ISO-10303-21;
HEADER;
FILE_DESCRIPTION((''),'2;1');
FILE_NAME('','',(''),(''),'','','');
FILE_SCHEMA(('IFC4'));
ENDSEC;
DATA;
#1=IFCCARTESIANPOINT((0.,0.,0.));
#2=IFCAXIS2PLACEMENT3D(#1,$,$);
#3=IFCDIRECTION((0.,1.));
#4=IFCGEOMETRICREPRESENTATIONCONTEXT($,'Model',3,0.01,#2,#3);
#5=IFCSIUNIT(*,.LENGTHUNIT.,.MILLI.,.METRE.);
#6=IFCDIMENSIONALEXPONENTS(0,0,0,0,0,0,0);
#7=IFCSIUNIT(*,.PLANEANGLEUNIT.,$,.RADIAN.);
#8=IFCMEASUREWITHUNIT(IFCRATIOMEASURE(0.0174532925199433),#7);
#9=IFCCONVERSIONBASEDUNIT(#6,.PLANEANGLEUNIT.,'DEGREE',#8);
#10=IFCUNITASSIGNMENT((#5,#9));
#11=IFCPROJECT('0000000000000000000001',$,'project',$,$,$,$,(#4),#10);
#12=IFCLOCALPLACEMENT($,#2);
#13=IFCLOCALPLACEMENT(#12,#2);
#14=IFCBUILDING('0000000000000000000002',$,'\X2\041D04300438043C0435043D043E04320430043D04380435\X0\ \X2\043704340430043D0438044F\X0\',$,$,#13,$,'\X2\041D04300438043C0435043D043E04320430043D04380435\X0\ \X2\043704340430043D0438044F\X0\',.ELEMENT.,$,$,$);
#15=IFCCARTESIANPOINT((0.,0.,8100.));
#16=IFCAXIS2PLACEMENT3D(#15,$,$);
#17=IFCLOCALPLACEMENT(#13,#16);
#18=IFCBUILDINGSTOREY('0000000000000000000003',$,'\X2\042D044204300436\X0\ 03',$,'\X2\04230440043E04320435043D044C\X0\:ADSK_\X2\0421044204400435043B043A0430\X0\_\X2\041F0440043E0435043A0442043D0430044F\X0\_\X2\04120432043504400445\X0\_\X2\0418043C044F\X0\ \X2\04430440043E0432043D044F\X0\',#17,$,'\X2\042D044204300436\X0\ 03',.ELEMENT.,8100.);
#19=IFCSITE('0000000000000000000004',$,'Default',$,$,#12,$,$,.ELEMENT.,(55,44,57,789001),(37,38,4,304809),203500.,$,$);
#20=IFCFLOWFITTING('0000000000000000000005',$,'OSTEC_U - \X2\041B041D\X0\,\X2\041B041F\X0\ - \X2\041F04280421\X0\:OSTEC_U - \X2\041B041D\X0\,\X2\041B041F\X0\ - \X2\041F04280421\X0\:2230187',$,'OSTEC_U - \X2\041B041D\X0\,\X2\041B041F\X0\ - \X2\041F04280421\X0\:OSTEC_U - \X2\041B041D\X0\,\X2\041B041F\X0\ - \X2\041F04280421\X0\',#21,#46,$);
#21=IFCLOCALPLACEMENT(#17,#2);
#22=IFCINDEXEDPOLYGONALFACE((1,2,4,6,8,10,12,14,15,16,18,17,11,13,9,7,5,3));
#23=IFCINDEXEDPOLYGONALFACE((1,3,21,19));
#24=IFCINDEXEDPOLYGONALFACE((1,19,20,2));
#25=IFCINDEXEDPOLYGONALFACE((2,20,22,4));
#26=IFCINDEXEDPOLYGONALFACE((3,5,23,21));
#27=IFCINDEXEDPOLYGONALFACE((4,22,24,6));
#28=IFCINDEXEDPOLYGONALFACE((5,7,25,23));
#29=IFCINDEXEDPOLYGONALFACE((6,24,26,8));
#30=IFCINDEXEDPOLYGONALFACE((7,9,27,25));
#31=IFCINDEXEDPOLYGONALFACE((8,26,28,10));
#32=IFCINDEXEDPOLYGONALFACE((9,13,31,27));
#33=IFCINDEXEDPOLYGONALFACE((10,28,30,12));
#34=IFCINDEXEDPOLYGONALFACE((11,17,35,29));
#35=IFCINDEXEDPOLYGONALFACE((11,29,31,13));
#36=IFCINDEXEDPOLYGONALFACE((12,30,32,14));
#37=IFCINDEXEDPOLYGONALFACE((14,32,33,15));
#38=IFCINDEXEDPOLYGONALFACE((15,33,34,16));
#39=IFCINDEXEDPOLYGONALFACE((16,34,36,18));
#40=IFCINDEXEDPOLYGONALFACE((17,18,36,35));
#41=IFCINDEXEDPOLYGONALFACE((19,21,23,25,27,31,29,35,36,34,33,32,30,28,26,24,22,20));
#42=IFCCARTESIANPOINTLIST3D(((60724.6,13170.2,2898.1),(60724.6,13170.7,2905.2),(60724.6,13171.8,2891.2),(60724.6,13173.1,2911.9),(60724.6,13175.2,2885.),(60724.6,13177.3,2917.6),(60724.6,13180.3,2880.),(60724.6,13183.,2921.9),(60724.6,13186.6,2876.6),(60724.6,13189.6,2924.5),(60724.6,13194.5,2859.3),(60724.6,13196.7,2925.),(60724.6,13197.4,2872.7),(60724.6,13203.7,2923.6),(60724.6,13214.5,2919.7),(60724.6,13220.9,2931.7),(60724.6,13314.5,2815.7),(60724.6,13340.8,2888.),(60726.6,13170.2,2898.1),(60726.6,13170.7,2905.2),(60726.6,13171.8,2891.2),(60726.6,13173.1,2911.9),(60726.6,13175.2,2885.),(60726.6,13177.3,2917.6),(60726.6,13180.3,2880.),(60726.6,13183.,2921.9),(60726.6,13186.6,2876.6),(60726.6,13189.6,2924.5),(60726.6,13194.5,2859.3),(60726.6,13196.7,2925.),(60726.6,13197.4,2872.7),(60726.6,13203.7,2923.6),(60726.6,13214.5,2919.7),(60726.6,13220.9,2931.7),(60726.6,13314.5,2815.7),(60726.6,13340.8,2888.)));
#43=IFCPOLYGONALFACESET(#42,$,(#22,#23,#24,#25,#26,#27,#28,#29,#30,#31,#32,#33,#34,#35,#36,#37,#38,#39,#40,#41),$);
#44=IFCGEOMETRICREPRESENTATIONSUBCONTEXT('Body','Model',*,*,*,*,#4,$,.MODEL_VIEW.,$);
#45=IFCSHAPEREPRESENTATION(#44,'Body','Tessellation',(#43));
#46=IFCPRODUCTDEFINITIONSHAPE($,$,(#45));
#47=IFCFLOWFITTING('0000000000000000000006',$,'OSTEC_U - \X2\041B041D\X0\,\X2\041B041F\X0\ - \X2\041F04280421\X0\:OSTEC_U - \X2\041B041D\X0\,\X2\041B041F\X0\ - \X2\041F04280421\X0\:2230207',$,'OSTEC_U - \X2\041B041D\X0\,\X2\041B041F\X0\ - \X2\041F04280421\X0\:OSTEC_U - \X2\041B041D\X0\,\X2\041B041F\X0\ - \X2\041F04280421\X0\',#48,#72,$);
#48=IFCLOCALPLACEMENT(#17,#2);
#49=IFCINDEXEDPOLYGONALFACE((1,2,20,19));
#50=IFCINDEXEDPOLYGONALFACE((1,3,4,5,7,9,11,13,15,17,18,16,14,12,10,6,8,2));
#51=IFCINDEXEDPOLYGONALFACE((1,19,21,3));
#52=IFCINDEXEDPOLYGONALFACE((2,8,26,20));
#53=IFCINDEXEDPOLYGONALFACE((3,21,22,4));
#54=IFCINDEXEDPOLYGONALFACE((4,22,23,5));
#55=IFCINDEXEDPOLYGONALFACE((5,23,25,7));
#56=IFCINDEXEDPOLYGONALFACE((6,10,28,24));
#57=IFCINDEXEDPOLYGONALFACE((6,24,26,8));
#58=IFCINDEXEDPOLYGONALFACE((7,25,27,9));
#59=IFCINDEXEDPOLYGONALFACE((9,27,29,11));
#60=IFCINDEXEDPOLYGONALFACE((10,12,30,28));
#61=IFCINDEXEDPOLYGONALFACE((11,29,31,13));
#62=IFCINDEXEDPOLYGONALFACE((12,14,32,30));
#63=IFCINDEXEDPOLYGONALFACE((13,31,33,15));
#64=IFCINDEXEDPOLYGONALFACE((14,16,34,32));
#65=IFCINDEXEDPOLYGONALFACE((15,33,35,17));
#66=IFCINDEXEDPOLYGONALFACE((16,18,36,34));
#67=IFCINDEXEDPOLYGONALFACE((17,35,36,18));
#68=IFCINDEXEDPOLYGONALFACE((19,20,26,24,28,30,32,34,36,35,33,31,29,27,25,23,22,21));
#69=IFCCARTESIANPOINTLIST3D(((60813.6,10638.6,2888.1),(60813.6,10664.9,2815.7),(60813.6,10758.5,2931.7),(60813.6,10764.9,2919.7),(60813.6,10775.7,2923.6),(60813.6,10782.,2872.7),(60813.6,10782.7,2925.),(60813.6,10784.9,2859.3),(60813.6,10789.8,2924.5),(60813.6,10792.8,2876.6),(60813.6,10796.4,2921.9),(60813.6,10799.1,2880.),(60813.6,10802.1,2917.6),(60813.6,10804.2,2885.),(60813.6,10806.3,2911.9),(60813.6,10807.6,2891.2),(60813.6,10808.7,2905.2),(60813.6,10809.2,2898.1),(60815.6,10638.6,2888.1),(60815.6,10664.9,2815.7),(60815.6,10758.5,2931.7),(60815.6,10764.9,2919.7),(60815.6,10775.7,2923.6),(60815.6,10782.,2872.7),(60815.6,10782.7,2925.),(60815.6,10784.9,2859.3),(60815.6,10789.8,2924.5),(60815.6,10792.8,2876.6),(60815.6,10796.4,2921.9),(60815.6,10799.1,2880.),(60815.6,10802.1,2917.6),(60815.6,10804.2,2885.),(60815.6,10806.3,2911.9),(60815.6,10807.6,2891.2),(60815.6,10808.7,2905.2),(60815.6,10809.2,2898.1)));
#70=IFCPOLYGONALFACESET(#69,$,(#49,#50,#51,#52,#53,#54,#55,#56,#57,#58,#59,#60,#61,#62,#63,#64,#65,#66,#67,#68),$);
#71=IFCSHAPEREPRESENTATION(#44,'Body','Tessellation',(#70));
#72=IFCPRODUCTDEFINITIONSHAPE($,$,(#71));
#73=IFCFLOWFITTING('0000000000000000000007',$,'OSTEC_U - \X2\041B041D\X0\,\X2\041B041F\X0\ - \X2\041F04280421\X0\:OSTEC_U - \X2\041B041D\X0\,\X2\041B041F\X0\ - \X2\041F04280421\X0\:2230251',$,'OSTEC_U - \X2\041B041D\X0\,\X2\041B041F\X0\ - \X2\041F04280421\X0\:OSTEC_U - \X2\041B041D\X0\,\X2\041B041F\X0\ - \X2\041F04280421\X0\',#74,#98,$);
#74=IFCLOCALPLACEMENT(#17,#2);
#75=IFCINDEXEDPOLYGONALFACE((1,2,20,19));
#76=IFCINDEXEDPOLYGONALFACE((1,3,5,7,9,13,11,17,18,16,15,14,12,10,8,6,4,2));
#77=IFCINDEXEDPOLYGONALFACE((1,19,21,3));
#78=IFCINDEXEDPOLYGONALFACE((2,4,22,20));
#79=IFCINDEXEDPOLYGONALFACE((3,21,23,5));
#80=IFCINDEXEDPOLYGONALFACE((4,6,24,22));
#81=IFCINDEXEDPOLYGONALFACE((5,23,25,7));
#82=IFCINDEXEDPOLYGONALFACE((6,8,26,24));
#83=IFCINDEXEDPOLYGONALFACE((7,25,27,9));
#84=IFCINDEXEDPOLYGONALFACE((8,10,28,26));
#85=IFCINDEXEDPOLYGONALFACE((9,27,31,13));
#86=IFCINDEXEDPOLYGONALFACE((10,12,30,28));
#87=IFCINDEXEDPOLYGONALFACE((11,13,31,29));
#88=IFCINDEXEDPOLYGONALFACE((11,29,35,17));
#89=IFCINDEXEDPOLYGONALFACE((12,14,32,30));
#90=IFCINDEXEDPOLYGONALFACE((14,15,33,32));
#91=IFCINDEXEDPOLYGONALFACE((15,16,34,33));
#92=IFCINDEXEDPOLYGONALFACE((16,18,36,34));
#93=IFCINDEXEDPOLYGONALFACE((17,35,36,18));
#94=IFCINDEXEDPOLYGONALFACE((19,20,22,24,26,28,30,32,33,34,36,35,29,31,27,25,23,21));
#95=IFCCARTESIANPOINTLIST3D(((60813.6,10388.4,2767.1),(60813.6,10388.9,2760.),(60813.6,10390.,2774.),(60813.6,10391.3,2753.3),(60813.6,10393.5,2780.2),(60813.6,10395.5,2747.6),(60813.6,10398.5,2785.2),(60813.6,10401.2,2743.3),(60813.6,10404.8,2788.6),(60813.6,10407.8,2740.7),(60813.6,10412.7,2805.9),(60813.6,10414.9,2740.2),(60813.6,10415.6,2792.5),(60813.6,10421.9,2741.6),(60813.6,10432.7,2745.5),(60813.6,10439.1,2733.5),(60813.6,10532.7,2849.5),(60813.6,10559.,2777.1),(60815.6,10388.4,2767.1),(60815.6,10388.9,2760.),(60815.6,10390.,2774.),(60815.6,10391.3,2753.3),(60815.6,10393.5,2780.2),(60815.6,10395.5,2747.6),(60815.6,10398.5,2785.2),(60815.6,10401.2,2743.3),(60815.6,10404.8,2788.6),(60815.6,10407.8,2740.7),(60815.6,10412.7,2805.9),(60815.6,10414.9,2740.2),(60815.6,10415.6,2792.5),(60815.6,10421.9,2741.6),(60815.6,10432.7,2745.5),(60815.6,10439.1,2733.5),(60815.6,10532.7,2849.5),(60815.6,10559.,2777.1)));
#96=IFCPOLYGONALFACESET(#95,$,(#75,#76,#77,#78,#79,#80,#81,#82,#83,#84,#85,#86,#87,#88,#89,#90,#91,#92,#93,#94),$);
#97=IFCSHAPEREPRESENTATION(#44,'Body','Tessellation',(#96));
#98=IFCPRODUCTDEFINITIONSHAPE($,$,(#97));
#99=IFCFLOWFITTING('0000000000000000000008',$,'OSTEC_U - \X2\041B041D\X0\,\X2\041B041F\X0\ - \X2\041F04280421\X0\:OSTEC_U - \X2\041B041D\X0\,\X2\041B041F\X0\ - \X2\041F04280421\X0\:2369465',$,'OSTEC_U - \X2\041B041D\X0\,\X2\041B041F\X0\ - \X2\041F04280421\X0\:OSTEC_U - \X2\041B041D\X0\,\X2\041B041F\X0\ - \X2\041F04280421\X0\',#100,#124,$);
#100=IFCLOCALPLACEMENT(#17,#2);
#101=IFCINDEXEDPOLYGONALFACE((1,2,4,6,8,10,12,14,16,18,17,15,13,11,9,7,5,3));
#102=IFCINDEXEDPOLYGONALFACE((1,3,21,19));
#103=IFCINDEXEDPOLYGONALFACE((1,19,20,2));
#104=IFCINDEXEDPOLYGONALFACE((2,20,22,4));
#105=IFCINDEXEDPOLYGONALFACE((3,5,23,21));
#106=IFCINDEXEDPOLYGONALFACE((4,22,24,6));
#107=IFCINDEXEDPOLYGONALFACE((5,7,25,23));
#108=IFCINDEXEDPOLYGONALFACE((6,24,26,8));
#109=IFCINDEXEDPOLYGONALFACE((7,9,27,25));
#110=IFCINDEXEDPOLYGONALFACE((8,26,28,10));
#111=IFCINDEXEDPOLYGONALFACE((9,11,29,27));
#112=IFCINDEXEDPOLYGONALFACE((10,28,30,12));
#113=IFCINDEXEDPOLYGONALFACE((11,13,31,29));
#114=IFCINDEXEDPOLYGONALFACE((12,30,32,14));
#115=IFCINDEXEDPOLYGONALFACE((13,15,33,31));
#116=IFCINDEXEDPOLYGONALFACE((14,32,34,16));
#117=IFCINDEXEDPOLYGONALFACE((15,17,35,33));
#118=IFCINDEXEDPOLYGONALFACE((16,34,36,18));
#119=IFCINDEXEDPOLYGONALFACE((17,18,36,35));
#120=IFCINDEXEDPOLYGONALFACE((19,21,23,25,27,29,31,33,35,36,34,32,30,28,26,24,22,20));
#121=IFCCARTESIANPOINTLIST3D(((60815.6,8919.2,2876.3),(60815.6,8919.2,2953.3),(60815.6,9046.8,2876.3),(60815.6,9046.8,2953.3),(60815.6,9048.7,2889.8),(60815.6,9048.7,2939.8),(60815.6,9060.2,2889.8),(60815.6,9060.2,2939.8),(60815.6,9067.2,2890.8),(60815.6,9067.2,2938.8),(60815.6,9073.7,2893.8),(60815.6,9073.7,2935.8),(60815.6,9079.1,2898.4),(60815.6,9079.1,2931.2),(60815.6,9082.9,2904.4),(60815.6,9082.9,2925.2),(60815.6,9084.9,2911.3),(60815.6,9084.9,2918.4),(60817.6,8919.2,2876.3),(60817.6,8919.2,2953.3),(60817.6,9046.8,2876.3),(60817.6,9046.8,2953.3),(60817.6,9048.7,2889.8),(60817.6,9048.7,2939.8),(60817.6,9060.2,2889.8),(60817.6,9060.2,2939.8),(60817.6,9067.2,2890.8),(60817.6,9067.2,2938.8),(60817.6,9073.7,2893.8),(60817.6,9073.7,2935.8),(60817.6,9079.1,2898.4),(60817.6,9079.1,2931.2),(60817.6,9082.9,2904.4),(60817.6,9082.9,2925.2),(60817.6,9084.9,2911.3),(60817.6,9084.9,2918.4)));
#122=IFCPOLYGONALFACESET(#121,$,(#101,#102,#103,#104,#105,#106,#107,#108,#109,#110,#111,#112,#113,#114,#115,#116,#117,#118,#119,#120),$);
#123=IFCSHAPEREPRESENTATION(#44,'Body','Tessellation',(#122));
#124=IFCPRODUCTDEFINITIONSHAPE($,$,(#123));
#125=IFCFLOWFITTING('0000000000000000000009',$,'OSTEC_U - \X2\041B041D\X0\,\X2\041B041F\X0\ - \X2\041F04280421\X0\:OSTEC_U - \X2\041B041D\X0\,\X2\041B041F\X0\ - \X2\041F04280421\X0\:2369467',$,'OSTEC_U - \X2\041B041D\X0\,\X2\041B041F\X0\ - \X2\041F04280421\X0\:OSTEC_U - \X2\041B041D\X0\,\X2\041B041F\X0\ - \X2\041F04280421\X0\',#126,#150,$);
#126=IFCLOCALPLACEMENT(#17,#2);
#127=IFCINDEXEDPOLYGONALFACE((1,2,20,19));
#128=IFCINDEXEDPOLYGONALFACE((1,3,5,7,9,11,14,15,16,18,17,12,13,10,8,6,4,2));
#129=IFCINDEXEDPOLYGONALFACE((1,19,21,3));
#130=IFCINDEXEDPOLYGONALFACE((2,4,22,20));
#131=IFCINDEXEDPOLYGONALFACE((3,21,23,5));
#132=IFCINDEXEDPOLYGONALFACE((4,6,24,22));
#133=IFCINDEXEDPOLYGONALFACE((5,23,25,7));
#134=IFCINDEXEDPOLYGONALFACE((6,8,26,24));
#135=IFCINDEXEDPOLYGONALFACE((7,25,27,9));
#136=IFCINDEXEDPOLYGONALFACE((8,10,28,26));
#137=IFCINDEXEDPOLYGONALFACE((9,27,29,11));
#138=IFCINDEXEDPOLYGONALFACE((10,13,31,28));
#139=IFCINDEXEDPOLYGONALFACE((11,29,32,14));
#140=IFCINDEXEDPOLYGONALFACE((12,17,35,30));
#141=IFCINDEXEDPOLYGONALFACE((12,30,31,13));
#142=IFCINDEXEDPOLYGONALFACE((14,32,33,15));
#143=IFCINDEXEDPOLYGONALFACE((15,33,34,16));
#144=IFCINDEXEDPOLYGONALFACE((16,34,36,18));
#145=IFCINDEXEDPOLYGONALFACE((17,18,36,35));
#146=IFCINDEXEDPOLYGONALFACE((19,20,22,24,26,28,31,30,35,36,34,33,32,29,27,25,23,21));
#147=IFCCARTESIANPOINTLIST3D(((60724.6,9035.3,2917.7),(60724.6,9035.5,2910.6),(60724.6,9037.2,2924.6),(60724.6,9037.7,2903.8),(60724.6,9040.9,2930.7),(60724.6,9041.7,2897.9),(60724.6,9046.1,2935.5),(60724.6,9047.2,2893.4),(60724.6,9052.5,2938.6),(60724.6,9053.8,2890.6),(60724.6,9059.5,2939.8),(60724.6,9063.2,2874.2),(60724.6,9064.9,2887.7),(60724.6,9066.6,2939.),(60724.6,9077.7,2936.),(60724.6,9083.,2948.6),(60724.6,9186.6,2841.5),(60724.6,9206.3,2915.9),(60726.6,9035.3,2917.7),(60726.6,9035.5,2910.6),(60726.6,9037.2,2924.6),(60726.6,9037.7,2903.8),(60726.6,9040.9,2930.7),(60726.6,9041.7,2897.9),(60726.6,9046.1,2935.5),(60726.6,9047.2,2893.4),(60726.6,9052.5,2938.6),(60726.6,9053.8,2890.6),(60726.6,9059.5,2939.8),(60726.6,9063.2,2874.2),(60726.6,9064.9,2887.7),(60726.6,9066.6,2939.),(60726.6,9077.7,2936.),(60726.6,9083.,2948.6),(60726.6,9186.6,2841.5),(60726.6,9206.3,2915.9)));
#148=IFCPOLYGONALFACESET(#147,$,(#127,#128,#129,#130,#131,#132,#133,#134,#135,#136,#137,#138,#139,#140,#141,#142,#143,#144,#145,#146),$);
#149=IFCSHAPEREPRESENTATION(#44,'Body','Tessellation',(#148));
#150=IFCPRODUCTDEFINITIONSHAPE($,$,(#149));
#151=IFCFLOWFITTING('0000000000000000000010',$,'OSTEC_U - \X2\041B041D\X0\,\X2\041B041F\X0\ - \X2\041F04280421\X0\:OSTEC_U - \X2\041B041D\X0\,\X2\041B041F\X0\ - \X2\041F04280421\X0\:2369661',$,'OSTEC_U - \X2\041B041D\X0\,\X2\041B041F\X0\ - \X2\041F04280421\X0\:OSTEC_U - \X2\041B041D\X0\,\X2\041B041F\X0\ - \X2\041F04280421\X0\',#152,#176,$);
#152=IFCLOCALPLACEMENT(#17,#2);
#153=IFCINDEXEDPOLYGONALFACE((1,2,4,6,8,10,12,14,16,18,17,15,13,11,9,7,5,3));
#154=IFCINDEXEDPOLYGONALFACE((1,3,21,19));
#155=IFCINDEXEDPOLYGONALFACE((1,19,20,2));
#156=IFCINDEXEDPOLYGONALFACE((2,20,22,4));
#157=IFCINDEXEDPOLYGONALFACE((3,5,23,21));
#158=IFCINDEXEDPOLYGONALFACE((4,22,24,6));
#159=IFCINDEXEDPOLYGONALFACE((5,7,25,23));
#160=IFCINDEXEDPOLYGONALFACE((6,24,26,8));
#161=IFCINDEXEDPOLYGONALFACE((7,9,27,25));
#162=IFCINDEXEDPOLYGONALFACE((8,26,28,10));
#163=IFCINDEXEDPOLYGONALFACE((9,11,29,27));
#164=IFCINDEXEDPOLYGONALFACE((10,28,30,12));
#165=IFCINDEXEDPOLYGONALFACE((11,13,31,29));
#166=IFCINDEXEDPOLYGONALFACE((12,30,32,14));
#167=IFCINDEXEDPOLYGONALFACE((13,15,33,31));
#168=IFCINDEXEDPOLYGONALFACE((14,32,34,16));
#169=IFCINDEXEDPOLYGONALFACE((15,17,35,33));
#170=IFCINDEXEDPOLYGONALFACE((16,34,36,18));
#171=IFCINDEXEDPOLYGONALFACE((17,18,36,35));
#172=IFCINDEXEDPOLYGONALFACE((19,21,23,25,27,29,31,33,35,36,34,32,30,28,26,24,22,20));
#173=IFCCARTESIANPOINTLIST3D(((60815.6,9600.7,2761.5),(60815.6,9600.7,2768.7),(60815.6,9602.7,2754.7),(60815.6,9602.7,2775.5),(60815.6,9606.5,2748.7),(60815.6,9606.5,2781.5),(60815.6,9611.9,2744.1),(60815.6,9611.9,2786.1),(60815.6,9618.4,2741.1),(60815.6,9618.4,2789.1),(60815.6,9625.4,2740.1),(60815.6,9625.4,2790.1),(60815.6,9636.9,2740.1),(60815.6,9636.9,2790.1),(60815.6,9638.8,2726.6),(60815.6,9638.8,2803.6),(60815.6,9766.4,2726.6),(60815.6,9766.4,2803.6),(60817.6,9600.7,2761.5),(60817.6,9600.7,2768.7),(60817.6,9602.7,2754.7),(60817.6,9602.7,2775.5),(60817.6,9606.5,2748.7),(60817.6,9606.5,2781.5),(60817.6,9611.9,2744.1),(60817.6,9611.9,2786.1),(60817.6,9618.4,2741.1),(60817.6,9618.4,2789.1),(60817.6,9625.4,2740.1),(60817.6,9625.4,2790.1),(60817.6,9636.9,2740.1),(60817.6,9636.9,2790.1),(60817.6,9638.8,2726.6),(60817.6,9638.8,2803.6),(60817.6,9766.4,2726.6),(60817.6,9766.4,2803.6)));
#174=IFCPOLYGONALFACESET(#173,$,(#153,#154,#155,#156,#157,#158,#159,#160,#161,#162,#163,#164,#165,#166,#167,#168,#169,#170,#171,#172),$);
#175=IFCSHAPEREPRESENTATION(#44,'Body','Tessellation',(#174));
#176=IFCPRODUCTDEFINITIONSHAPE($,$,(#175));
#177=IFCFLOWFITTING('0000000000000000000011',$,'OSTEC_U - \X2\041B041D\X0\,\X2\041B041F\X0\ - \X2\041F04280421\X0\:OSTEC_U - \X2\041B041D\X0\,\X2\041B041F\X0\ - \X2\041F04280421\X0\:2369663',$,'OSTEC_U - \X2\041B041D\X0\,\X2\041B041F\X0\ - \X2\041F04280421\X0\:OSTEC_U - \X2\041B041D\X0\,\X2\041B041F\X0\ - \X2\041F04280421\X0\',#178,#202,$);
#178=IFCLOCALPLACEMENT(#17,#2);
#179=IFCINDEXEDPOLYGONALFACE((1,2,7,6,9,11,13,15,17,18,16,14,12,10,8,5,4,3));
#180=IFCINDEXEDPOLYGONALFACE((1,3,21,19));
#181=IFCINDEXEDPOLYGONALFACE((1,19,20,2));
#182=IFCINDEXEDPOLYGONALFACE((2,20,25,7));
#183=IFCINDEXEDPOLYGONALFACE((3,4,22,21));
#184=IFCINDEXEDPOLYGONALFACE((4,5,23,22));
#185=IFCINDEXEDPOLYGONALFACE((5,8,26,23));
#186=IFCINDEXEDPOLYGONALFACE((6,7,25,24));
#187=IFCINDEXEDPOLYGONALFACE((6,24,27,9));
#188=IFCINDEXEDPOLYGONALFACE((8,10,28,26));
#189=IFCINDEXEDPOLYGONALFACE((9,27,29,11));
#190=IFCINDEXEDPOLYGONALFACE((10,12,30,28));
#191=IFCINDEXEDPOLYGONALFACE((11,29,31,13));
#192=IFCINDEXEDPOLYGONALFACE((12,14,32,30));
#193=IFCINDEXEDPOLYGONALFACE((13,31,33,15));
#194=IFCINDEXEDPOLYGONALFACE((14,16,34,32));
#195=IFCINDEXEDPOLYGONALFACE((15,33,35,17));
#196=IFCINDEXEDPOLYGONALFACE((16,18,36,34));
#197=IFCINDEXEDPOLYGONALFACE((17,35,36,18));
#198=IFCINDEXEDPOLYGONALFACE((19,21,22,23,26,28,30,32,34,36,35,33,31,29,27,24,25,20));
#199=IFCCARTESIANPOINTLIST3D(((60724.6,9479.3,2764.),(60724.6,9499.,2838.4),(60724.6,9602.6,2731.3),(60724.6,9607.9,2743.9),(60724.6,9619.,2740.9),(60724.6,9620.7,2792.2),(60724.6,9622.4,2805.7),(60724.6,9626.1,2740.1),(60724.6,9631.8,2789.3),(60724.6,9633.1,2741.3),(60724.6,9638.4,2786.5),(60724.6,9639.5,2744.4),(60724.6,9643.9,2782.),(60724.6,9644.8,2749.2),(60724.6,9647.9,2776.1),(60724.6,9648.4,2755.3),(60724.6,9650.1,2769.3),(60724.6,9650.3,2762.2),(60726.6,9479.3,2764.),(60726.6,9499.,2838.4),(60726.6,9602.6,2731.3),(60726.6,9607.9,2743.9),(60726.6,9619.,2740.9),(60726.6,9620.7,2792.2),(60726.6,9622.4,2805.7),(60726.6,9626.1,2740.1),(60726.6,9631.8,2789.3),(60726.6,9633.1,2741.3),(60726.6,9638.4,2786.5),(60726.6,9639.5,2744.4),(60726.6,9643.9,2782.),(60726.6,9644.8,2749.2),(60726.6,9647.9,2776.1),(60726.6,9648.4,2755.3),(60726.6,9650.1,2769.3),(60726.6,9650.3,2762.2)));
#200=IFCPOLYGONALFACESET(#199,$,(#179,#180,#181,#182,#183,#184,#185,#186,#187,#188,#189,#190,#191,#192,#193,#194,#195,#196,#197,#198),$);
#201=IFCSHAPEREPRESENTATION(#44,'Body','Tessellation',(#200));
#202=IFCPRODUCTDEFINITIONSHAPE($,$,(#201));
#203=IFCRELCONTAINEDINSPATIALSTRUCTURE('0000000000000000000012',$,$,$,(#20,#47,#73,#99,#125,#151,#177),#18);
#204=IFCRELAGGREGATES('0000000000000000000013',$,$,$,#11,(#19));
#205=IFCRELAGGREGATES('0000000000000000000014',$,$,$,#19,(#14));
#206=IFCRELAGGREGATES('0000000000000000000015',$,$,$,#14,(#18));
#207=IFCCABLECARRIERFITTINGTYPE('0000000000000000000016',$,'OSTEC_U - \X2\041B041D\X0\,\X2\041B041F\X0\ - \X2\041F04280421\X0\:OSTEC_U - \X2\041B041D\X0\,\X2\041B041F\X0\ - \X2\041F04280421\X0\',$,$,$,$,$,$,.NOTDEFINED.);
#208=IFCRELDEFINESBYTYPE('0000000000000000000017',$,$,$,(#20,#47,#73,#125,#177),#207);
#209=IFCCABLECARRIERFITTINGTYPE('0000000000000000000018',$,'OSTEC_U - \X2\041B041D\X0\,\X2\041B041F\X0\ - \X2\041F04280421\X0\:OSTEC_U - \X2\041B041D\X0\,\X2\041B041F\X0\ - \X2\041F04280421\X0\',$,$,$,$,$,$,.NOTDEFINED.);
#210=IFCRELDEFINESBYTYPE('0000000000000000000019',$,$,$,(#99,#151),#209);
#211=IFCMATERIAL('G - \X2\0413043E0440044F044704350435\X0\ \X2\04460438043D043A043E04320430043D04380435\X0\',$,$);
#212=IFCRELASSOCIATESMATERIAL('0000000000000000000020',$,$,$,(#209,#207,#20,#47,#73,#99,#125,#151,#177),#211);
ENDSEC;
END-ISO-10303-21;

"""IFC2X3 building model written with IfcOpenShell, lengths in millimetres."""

from ifc_helpers import new_model, entity, si_unit, converted_unit, direction, frame, frame_2d, origin, place, context, subcontext, project, spatial, polyline, circle_curve, parameter, trimmed, segment, composite_curve, outline, extrude, source, transform, mapped, material, type_object, type_shapes, element, save


model = new_model("IFC2X3")

# Units and contexts
model_context = context("Model", 3, precision=0.01, world=origin(), true_north=direction((0.0, 1.0)))
body_context = subcontext(model_context, "Body", "Model", "MODEL_VIEW")
ifc_project = project(units=[si_unit("LENGTHUNIT", "METRE", prefix="MILLI"), converted_unit("PLANEANGLEUNIT", "DEGREE", entity("IfcRatioMeasure", 0.0174532925199433), si_unit("PLANEANGLEUNIT", "RADIAN"), dimensions=[0, 0, 0, 0, 0, 0, 0])], contexts=[model_context])

# Site, building, storey
site_placement = place(None, origin())
site = spatial("IfcSite", under=ifc_project, at=site_placement, Name="Default", CompositionType="ELEMENT", RefLatitude=(55, 44, 57, 789001), RefLongitude=(37, 38, 4, 304809), RefElevation=203500.0)
building_placement = place(site_placement, origin())
building = spatial("IfcBuilding", under=site, at=building_placement, Name="Наименование здания", LongName="Наименование здания", CompositionType="ELEMENT")
storey_placement = place(building_placement, frame((0.0, 0.0, 8100.0)))
storey = spatial("IfcBuildingStorey", under=building, at=storey_placement, Name="Этаж 03", ObjectType="Уровень:ADSK_Стрелка_Проектная_Вверх_Имя уровня", LongName="Этаж 03", CompositionType="ELEMENT", Elevation=8100.0)

# Flow fittings
ifc_material_1 = material(Name="G - Горячее цинкование")
cable_carrier_fitting_type_1 = type_object("IfcCableCarrierFittingType", Name="OSTEC_U - ЛН,ЛП - ПШС:OSTEC_U - ЛН,ЛП - ПШС", PredefinedType="NOTDEFINED", material=ifc_material_1)
shared_shape_1 = source(origin(), body_context, "Body", "SweptSolid", [
    extrude(outline(composite_curve([segment(trimmed(circle_curve(frame_2d((-41.5, 0.0), x_axis=(1.0, 0.0)), 25.0), [parameter(90.0)], [parameter(270.0)], True, "PARAMETER"), True, "CONTINUOUS"), segment(polyline([(-41.5, -25.0), (-30.0, -25.0)]), True, "CONTINUOUS"), segment(polyline([(-30.0, -25.0), (-28.1, -38.5)]), True, "CONTINUOUS"), segment(polyline([(-28.1, -38.5), (99.5, -38.5)]), True, "CONTINUOUS"), segment(polyline([(99.5, -38.5), (99.5, 38.5)]), True, "CONTINUOUS"), segment(polyline([(99.5, 38.5), (-28.1, 38.5)]), True, "CONTINUOUS"), segment(polyline([(-28.1, 38.5), (-30.0, 25.0)]), True, "CONTINUOUS"), segment(polyline([(-30.0, 25.0), (-41.5, 25.0)]), True, "CONTINUOUS")], self_intersect=False)), frame((41.5, 0.0, 0.0), z_axis=(0.0, 0.0, -1.0), x_axis=(1.0, 0.0, 0.0)), (0.0, 0.0, -1.0), 2.0),
])
type_shapes(cable_carrier_fitting_type_1, [shared_shape_1])
cable_carrier_fitting_type_2 = type_object("IfcCableCarrierFittingType", Name="OSTEC_U - ЛН,ЛП - ПШС:OSTEC_U - ЛН,ЛП - ПШС", PredefinedType="NOTDEFINED", material=ifc_material_1)
type_shapes(cable_carrier_fitting_type_2, [shared_shape_1])
for number, where, z_axis, x_axis, name in (
    (1, (60726.7, 13195.1, 2900.1), (-1.0, 0.0, 0.0), (0.0, 0.939662, -0.342104), "OSTEC_U - ЛН,ЛП - ПШС:OSTEC_U - ЛН,ЛП - ПШС:2230187"),
    (2, (60813.6, 10784.3, 2900.1), (1.0, 0.0, 0.0), (0.0, -0.939693, -0.34202), "OSTEC_U - ЛН,ЛП - ПШС:OSTEC_U - ЛН,ЛП - ПШС:2230207"),
    (3, (60813.6, 10413.4, 2765.1), (1.0, 0.0, 0.0), (0.0, 0.939693, 0.34202), "OSTEC_U - ЛН,ЛП - ПШС:OSTEC_U - ЛН,ЛП - ПШС:2230251"),
):
    element("IfcFlowFitting", number, at=place(storey_placement, frame(where, z_axis=z_axis, x_axis=x_axis)), inside=storey, type_object=cable_carrier_fitting_type_2, material=ifc_material_1, Name=name, ObjectType="OSTEC_U - ЛН,ЛП - ПШС:OSTEC_U - ЛН,ЛП - ПШС", context=body_context, shape_type="MappedRepresentation", body=[
        mapped(shared_shape_1, transform((0.0, 0.0, 0.0), scale=1.0)),
    ])
flow_fitting_1_placement = place(storey_placement, frame((60815.6, 9060.2, 2914.8), z_axis=(1.0, 0.0, 0.0), x_axis=(0.0, -1.0, 0.0)))
element("IfcFlowFitting", 4, at=flow_fitting_1_placement, inside=storey, type_object=cable_carrier_fitting_type_1, material=ifc_material_1, Name="OSTEC_U - ЛН,ЛП - ПШС:OSTEC_U - ЛН,ЛП - ПШС:2369465", ObjectType="OSTEC_U - ЛН,ЛП - ПШС:OSTEC_U - ЛН,ЛП - ПШС", context=body_context, shape_type="MappedRepresentation", body=[
    mapped(shared_shape_1, transform((0.0, 0.0, 0.0), scale=1.0)),
])
flow_fitting_2_placement = place(storey_placement, frame((60726.7, 9060.2, 2914.8), z_axis=(-1.0, 0.0, 0.0), x_axis=(0.0, 0.966668, -0.256034)))
element("IfcFlowFitting", 5, at=flow_fitting_2_placement, inside=storey, type_object=cable_carrier_fitting_type_2, material=ifc_material_1, Name="OSTEC_U - ЛН,ЛП - ПШС:OSTEC_U - ЛН,ЛП - ПШС:2369467", ObjectType="OSTEC_U - ЛН,ЛП - ПШС:OSTEC_U - ЛН,ЛП - ПШС", context=body_context, shape_type="MappedRepresentation", body=[
    mapped(shared_shape_1, transform((0.0, 0.0, 0.0), scale=1.0)),
])
flow_fitting_3_placement = place(storey_placement, frame((60815.6, 9625.4, 2765.1), z_axis=(1.0, 0.0, 0.0), x_axis=(0.0, 1.0, -0.000005)))
element("IfcFlowFitting", 6, at=flow_fitting_3_placement, inside=storey, type_object=cable_carrier_fitting_type_1, material=ifc_material_1, Name="OSTEC_U - ЛН,ЛП - ПШС:OSTEC_U - ЛН,ЛП - ПШС:2369661", ObjectType="OSTEC_U - ЛН,ЛП - ПШС:OSTEC_U - ЛН,ЛП - ПШС", context=body_context, shape_type="MappedRepresentation", body=[
    mapped(shared_shape_1, transform((0.0, 0.0, 0.0), scale=1.0)),
])
flow_fitting_4_placement = place(storey_placement, frame((60726.7, 9625.4, 2765.1), z_axis=(-1.0, 0.0, 0.0), x_axis=(0.0, -0.966668, 0.256034)))
element("IfcFlowFitting", 7, at=flow_fitting_4_placement, inside=storey, type_object=cable_carrier_fitting_type_2, material=ifc_material_1, Name="OSTEC_U - ЛН,ЛП - ПШС:OSTEC_U - ЛН,ЛП - ПШС:2369663", ObjectType="OSTEC_U - ЛН,ЛП - ПШС:OSTEC_U - ЛН,ЛП - ПШС", context=body_context, shape_type="MappedRepresentation", body=[
    mapped(shared_shape_1, transform((0.0, 0.0, 0.0), scale=1.0)),
])

save(model, "model.ifc")
